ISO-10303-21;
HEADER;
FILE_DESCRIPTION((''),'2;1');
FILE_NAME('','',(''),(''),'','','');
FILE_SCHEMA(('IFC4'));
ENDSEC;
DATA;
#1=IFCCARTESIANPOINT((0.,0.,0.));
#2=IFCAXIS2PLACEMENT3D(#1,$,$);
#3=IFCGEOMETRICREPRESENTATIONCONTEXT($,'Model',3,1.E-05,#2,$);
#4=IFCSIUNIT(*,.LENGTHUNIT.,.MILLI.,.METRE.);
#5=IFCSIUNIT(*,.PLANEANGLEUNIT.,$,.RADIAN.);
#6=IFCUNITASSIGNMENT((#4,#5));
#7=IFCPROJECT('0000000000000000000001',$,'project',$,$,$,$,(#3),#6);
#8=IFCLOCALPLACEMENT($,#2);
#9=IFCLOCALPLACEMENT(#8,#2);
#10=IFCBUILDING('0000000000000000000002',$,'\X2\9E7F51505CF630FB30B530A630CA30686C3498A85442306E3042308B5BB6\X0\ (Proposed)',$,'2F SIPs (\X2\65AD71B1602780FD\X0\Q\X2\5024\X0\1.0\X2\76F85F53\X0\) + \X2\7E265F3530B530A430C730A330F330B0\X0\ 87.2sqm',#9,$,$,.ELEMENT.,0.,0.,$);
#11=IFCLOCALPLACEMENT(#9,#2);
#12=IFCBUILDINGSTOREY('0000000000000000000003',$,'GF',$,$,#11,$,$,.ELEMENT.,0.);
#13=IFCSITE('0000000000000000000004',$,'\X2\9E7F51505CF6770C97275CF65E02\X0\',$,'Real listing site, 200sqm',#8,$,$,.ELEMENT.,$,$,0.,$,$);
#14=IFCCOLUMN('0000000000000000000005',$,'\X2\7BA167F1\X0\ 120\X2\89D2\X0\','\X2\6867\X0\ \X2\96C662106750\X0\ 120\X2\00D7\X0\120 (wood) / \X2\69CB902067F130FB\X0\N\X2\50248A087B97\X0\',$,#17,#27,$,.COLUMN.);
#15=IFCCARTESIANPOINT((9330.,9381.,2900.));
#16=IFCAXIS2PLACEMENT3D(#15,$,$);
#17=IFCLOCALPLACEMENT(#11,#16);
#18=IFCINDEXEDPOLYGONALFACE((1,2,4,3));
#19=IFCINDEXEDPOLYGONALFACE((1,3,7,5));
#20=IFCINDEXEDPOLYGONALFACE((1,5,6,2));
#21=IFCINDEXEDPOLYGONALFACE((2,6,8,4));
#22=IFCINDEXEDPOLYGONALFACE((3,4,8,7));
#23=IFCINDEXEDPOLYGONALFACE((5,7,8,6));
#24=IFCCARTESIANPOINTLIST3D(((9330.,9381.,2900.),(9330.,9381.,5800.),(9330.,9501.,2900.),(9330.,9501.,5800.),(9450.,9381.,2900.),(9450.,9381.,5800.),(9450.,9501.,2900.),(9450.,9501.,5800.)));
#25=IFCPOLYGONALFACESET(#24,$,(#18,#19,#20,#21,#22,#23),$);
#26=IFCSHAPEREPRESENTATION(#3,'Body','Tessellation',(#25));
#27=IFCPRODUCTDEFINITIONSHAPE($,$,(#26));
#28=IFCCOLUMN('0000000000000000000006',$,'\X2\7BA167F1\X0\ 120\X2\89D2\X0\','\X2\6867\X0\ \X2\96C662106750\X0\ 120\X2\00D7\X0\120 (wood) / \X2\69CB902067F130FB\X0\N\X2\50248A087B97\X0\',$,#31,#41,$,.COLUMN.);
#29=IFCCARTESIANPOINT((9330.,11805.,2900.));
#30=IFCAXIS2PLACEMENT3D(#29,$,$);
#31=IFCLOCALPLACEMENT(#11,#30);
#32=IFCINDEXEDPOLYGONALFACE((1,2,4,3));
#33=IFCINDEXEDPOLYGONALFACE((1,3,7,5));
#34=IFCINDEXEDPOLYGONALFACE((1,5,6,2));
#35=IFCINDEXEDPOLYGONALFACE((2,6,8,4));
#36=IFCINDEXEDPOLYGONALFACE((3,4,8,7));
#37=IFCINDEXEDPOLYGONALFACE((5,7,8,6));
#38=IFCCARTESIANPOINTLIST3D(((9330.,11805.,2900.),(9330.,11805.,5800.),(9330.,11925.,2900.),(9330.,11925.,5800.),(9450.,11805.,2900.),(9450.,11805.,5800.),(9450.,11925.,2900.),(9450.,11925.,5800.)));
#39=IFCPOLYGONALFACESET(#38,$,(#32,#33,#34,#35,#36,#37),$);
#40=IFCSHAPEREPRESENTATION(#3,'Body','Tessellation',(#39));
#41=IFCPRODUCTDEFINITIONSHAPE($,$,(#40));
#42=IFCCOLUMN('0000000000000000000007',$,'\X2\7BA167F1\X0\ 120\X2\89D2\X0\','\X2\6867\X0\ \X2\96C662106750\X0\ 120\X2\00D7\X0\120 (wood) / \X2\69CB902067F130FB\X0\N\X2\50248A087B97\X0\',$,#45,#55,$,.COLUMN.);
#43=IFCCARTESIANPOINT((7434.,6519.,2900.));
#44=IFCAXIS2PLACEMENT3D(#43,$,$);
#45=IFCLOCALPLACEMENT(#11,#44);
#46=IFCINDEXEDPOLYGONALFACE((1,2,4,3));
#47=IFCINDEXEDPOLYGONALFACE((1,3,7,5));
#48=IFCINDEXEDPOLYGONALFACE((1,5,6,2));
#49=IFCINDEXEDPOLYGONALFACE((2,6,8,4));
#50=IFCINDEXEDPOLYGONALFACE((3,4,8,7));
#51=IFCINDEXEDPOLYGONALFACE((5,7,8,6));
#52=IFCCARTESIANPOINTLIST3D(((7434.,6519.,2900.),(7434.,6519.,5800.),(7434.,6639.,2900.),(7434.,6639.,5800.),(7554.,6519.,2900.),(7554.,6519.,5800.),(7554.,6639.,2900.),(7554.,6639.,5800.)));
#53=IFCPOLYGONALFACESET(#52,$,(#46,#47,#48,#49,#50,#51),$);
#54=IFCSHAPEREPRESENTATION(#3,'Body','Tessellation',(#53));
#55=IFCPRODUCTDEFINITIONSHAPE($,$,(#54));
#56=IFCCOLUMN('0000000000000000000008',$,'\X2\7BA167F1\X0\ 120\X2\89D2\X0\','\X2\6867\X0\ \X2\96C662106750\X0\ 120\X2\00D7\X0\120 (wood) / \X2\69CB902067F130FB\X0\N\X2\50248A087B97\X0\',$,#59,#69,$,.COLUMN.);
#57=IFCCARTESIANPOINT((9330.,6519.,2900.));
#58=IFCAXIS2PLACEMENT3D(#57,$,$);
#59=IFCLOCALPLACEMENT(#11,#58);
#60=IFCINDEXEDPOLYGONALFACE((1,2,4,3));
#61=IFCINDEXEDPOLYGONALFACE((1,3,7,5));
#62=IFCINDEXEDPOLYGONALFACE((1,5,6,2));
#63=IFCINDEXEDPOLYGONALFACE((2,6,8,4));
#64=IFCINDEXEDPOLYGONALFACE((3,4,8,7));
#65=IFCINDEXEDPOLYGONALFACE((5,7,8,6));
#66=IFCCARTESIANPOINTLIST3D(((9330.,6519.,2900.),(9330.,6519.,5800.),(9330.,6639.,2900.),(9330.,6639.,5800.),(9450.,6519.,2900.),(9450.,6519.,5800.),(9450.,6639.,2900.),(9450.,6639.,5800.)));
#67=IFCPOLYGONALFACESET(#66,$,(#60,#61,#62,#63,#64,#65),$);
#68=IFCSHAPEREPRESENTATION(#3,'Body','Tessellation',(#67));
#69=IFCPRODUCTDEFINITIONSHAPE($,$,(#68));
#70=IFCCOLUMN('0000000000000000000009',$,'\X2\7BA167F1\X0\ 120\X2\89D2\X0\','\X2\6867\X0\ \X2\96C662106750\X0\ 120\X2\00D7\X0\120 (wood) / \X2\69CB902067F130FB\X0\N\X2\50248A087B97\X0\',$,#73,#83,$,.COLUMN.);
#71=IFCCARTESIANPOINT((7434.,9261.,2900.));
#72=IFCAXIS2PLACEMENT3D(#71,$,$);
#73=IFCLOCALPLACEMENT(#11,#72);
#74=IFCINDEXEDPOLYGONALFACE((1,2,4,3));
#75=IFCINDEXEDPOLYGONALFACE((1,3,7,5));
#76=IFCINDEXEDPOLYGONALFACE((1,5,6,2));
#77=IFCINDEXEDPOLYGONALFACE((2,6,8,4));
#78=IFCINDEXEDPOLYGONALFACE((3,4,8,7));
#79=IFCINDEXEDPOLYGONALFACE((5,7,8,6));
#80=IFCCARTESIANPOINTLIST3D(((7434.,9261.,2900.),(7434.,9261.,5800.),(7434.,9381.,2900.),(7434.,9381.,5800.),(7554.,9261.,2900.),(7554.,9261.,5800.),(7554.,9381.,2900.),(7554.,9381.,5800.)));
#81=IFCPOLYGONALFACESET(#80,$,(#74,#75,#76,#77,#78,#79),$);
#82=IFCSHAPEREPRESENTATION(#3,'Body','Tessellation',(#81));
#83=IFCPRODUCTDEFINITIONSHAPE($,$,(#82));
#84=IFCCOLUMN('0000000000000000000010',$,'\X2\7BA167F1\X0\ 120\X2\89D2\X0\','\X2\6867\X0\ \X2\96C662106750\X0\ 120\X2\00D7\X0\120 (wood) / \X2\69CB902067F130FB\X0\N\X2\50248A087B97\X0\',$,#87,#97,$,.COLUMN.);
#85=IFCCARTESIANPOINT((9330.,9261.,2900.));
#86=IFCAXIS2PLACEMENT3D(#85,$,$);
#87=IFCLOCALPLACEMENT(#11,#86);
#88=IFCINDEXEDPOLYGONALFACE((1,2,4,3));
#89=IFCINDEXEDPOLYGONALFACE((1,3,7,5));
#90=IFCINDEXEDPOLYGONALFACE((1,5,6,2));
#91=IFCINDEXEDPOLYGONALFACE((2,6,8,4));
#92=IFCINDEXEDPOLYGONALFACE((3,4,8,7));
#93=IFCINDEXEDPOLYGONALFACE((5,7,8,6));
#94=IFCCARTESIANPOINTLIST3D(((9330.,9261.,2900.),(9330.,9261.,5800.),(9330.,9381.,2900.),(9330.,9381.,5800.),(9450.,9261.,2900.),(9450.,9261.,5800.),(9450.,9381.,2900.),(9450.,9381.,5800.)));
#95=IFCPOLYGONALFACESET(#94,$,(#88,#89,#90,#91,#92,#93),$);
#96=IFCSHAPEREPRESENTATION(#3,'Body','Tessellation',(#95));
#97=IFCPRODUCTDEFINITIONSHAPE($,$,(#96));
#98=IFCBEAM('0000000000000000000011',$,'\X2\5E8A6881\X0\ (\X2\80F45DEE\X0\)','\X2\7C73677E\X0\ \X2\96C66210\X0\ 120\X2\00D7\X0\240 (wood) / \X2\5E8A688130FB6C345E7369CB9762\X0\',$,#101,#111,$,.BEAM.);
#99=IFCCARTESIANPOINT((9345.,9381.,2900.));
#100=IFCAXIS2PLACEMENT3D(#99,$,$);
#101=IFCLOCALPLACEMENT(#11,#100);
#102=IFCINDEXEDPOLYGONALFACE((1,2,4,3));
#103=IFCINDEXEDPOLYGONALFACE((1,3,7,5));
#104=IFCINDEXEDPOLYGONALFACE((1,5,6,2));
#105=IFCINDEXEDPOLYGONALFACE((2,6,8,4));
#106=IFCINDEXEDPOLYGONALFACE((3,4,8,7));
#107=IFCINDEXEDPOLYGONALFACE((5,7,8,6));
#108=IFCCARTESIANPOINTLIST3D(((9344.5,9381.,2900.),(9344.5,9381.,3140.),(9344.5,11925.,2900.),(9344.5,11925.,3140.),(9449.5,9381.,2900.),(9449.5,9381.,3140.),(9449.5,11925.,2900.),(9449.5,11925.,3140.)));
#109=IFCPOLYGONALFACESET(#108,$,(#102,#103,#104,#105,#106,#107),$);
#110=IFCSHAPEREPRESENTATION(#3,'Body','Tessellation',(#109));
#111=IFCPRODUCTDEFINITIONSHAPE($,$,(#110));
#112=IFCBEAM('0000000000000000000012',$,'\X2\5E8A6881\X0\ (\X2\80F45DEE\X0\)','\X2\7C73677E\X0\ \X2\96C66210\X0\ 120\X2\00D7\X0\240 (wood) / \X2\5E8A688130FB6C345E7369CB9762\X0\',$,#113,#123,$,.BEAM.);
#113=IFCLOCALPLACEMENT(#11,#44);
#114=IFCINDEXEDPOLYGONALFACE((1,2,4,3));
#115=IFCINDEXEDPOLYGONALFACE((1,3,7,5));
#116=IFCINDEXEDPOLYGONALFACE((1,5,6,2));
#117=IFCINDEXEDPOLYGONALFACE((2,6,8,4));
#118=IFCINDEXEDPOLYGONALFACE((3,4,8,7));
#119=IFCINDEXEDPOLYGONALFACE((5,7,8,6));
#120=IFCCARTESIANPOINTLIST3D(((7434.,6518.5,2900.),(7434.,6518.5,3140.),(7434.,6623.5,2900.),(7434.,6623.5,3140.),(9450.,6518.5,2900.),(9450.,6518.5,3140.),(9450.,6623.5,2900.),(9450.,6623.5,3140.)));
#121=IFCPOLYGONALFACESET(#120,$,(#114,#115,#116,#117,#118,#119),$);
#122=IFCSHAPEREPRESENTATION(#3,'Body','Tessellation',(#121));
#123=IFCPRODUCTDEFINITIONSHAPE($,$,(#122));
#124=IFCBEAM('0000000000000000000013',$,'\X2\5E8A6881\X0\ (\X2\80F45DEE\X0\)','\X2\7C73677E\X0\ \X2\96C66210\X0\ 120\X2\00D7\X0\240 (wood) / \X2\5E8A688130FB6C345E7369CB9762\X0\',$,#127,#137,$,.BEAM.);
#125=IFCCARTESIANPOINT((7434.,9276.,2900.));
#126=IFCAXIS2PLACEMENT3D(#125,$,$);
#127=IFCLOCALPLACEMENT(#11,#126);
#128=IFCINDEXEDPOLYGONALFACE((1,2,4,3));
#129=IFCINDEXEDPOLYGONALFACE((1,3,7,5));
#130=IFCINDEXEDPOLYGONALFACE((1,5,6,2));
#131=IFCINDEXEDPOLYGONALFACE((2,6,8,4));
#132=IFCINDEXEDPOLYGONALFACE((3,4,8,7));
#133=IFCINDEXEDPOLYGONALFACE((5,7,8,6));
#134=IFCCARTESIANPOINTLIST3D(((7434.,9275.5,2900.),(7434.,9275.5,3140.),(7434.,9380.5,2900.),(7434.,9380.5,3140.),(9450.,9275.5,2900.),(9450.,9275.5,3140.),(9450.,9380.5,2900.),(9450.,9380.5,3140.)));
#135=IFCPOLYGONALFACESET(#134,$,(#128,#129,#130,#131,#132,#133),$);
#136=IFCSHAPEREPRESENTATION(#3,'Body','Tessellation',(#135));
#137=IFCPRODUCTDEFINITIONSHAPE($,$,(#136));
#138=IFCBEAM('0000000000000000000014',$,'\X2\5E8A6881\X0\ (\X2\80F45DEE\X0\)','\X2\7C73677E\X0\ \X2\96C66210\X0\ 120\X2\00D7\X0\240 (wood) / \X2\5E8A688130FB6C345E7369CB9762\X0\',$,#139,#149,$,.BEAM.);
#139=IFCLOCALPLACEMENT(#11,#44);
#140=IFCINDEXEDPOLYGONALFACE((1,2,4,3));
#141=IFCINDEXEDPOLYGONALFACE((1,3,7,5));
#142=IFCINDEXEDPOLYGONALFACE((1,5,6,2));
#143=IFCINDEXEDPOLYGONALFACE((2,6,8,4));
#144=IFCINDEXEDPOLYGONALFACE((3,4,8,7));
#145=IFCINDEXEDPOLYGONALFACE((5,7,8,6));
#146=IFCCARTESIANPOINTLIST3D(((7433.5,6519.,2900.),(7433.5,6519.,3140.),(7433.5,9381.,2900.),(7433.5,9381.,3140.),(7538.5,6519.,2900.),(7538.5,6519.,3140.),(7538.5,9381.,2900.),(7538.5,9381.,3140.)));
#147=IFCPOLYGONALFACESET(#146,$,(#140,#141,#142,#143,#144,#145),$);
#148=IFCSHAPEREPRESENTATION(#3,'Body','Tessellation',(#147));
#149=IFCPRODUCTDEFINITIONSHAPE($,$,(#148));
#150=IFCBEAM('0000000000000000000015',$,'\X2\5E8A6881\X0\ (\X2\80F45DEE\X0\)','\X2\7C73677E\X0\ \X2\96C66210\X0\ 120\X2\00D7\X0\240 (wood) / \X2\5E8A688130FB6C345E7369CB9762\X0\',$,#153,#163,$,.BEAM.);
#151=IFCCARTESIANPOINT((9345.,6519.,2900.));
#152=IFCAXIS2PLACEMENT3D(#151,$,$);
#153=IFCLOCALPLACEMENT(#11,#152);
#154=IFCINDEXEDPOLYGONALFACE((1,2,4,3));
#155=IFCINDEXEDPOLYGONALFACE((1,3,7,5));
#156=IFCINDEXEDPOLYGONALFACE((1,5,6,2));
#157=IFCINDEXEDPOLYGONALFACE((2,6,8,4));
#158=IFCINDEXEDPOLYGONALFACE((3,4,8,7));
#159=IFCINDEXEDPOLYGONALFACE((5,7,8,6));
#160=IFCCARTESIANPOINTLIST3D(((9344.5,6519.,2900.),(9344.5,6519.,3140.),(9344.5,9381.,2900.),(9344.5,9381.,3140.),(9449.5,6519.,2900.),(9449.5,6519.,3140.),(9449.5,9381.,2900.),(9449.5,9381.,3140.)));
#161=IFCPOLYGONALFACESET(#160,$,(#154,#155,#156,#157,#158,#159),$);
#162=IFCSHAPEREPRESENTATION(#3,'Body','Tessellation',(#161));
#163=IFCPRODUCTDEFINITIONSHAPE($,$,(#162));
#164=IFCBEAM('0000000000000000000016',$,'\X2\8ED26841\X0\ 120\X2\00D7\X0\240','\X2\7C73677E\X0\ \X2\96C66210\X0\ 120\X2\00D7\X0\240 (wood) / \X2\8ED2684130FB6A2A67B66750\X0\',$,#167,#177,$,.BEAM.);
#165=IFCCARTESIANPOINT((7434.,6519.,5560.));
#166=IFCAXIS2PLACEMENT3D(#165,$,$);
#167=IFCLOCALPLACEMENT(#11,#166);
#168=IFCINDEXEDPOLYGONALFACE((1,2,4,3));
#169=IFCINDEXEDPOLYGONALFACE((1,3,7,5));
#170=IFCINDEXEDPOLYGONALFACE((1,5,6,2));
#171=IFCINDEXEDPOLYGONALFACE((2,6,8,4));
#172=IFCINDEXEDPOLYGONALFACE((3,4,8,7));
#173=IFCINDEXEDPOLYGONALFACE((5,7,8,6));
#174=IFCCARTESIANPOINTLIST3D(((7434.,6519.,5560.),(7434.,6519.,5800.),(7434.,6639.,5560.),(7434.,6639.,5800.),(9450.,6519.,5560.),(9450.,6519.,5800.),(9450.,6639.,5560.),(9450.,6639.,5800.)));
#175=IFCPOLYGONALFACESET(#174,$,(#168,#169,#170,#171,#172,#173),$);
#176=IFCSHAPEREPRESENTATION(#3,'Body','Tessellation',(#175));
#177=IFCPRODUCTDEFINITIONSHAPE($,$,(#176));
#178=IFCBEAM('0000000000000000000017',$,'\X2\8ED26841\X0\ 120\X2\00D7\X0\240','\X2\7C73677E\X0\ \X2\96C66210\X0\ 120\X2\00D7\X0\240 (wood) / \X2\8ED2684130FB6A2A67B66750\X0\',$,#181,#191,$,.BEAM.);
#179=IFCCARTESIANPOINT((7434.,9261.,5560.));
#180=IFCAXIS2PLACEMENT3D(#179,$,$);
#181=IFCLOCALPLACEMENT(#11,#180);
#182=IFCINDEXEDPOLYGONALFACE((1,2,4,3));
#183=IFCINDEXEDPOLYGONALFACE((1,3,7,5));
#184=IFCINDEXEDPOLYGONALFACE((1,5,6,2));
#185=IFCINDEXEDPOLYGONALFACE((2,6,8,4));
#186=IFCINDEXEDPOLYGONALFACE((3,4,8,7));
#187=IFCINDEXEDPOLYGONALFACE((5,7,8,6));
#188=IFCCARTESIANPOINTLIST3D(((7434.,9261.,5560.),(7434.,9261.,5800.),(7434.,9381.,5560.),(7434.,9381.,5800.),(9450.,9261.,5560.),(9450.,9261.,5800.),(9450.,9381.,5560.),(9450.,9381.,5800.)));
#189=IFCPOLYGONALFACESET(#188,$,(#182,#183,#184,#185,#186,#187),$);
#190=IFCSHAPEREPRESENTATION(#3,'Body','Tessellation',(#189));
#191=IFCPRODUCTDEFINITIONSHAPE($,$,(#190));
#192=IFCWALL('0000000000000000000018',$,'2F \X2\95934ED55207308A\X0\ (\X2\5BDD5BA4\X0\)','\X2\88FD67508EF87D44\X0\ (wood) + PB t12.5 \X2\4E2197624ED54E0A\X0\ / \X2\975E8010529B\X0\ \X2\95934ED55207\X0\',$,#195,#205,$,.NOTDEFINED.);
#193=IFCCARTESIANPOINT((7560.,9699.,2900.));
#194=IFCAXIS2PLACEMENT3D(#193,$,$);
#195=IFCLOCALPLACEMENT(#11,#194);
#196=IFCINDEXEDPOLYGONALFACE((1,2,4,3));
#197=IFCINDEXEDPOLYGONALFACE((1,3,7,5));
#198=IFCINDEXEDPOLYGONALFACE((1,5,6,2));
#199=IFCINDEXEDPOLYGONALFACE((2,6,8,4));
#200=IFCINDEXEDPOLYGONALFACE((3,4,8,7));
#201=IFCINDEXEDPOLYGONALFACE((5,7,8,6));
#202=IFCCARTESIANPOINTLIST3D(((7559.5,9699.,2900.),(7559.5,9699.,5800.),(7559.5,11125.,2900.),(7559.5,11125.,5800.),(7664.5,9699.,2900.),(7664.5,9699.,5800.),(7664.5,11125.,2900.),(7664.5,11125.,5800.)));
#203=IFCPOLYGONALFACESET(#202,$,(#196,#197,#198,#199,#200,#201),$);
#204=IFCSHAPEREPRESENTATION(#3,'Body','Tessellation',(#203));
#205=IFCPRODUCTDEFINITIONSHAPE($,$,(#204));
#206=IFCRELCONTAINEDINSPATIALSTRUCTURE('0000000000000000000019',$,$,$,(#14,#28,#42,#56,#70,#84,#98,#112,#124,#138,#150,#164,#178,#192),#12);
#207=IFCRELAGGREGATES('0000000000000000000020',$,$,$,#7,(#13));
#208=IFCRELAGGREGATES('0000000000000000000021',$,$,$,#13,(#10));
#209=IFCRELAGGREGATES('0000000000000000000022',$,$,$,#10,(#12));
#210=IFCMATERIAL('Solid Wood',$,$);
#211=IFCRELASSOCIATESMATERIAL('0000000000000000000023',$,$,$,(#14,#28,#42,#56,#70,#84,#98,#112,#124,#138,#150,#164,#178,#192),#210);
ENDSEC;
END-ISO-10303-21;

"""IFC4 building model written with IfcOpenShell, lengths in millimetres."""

from ifc_helpers import new_model, si_unit, frame, frame_2d, origin, place, context, project, spatial, rectangle, extrude, material, element, save


model = new_model("IFC4")

# Units and contexts
model_context = context("Model", 3, precision=1e-05, world=origin())
ifc_project = project(units=[si_unit("LENGTHUNIT", "METRE", prefix="MILLI"), si_unit("PLANEANGLEUNIT", "RADIAN")], contexts=[model_context])

# Site, building, storey
site_placement = place(None, origin())
site = spatial("IfcSite", under=ifc_project, at=site_placement, Name="鹿児島県霧島市", ObjectType="Real listing site, 200sqm", CompositionType="ELEMENT", RefElevation=0.0)
building_placement = place(site_placement, origin())
building = spatial("IfcBuilding", under=site, at=building_placement, Name="鹿児島・サウナと水風呂のある家 (Proposed)", ObjectType="2F SIPs (断熱性能Q値1.0相当) + 縦張サイディング 87.2sqm", CompositionType="ELEMENT", ElevationOfRefHeight=0.0, ElevationOfTerrain=0.0)
storey_placement = place(building_placement, origin())
storey = spatial("IfcBuildingStorey", under=building, at=storey_placement, Name="GF", CompositionType="ELEMENT", Elevation=0.0)

# Columns
ifc_material_1 = material(Name="Solid Wood")
column_1_placement = place(storey_placement, frame((9330.0, 9381.0, 2900.0)))
element("IfcColumn", 1, at=column_1_placement, inside=storey, material=ifc_material_1, Name="管柱 120角", Description="桧 集成材 120×120 (wood) / 構造柱・N値計算", PredefinedType="COLUMN", context=model_context, shape_type="SweptSolid", body=[
    extrude(rectangle(XDim=120.0, YDim=120.0, at=frame_2d((60.0, 60.0))), frame((9330.0, 9381.0, 2900.0)), (0.0, 0.0, 1.0), 2900.0),
])
column_2_placement = place(storey_placement, frame((9330.0, 11805.0, 2900.0)))
element("IfcColumn", 2, at=column_2_placement, inside=storey, material=ifc_material_1, Name="管柱 120角", Description="桧 集成材 120×120 (wood) / 構造柱・N値計算", PredefinedType="COLUMN", context=model_context, shape_type="SweptSolid", body=[
    extrude(rectangle(XDim=120.0, YDim=120.0, at=frame_2d((60.0, 60.0))), frame((9330.0, 11805.0, 2900.0)), (0.0, 0.0, 1.0), 2900.0),
])
column_3_placement = place(storey_placement, frame((7434.0, 6519.0, 2900.0)))
element("IfcColumn", 3, at=column_3_placement, inside=storey, material=ifc_material_1, Name="管柱 120角", Description="桧 集成材 120×120 (wood) / 構造柱・N値計算", PredefinedType="COLUMN", context=model_context, shape_type="SweptSolid", body=[
    extrude(rectangle(XDim=120.0, YDim=120.0, at=frame_2d((60.0, 60.0))), frame((7434.0, 6519.0, 2900.0)), (0.0, 0.0, 1.0), 2900.0),
])
column_4_placement = place(storey_placement, frame((9330.0, 6519.0, 2900.0)))
element("IfcColumn", 4, at=column_4_placement, inside=storey, material=ifc_material_1, Name="管柱 120角", Description="桧 集成材 120×120 (wood) / 構造柱・N値計算", PredefinedType="COLUMN", context=model_context, shape_type="SweptSolid", body=[
    extrude(rectangle(XDim=120.0, YDim=120.0, at=frame_2d((60.0, 60.0))), frame((9330.0, 6519.0, 2900.0)), (0.0, 0.0, 1.0), 2900.0),
])
column_5_placement = place(storey_placement, frame((7434.0, 9261.0, 2900.0)))
element("IfcColumn", 5, at=column_5_placement, inside=storey, material=ifc_material_1, Name="管柱 120角", Description="桧 集成材 120×120 (wood) / 構造柱・N値計算", PredefinedType="COLUMN", context=model_context, shape_type="SweptSolid", body=[
    extrude(rectangle(XDim=120.0, YDim=120.0, at=frame_2d((60.0, 60.0))), frame((7434.0, 9261.0, 2900.0)), (0.0, 0.0, 1.0), 2900.0),
])
column_6_placement = place(storey_placement, frame((9330.0, 9261.0, 2900.0)))
element("IfcColumn", 6, at=column_6_placement, inside=storey, material=ifc_material_1, Name="管柱 120角", Description="桧 集成材 120×120 (wood) / 構造柱・N値計算", PredefinedType="COLUMN", context=model_context, shape_type="SweptSolid", body=[
    extrude(rectangle(XDim=120.0, YDim=120.0, at=frame_2d((60.0, 60.0))), frame((9330.0, 9261.0, 2900.0)), (0.0, 0.0, 1.0), 2900.0),
])

# Beams
beam_1_placement = place(storey_placement, frame((9345.0, 9381.0, 2900.0)))
element("IfcBeam", 7, at=beam_1_placement, inside=storey, material=ifc_material_1, Name="床梁 (胴差)", Description="米松 集成 120×240 (wood) / 床梁・水平構面", PredefinedType="BEAM", context=model_context, shape_type="SweptSolid", body=[
    extrude(rectangle(XDim=105.0, YDim=2544.0, at=frame_2d((52.0, 1272.0))), frame((9345.0, 9381.0, 2900.0)), (0.0, 0.0, 1.0), 240.0),
])
beam_2_placement = place(storey_placement, frame((7434.0, 6519.0, 2900.0)))
element("IfcBeam", 8, at=beam_2_placement, inside=storey, material=ifc_material_1, Name="床梁 (胴差)", Description="米松 集成 120×240 (wood) / 床梁・水平構面", PredefinedType="BEAM", context=model_context, shape_type="SweptSolid", body=[
    extrude(rectangle(XDim=2016.0, YDim=105.0, at=frame_2d((1008.0, 52.0))), frame((7434.0, 6519.0, 2900.0)), (0.0, 0.0, 1.0), 240.0),
])
beam_3_placement = place(storey_placement, frame((7434.0, 9276.0, 2900.0)))
element("IfcBeam", 9, at=beam_3_placement, inside=storey, material=ifc_material_1, Name="床梁 (胴差)", Description="米松 集成 120×240 (wood) / 床梁・水平構面", PredefinedType="BEAM", context=model_context, shape_type="SweptSolid", body=[
    extrude(rectangle(XDim=2016.0, YDim=105.0, at=frame_2d((1008.0, 52.0))), frame((7434.0, 9276.0, 2900.0)), (0.0, 0.0, 1.0), 240.0),
])
beam_4_placement = place(storey_placement, frame((7434.0, 6519.0, 2900.0)))
element("IfcBeam", 10, at=beam_4_placement, inside=storey, material=ifc_material_1, Name="床梁 (胴差)", Description="米松 集成 120×240 (wood) / 床梁・水平構面", PredefinedType="BEAM", context=model_context, shape_type="SweptSolid", body=[
    extrude(rectangle(XDim=105.0, YDim=2862.0, at=frame_2d((52.0, 1431.0))), frame((7434.0, 6519.0, 2900.0)), (0.0, 0.0, 1.0), 240.0),
])
beam_5_placement = place(storey_placement, frame((9345.0, 6519.0, 2900.0)))
element("IfcBeam", 11, at=beam_5_placement, inside=storey, material=ifc_material_1, Name="床梁 (胴差)", Description="米松 集成 120×240 (wood) / 床梁・水平構面", PredefinedType="BEAM", context=model_context, shape_type="SweptSolid", body=[
    extrude(rectangle(XDim=105.0, YDim=2862.0, at=frame_2d((52.0, 1431.0))), frame((9345.0, 6519.0, 2900.0)), (0.0, 0.0, 1.0), 240.0),
])
beam_6_placement = place(storey_placement, frame((7434.0, 6519.0, 5560.0)))
element("IfcBeam", 12, at=beam_6_placement, inside=storey, material=ifc_material_1, Name="軒桁 120×240", Description="米松 集成 120×240 (wood) / 軒桁・横架材", PredefinedType="BEAM", context=model_context, shape_type="SweptSolid", body=[
    extrude(rectangle(XDim=2016.0, YDim=120.0, at=frame_2d((1008.0, 60.0))), frame((7434.0, 6519.0, 5560.0)), (0.0, 0.0, 1.0), 240.0),
])
beam_7_placement = place(storey_placement, frame((7434.0, 9261.0, 5560.0)))
element("IfcBeam", 13, at=beam_7_placement, inside=storey, material=ifc_material_1, Name="軒桁 120×240", Description="米松 集成 120×240 (wood) / 軒桁・横架材", PredefinedType="BEAM", context=model_context, shape_type="SweptSolid", body=[
    extrude(rectangle(XDim=2016.0, YDim=120.0, at=frame_2d((1008.0, 60.0))), frame((7434.0, 9261.0, 5560.0)), (0.0, 0.0, 1.0), 240.0),
])

# Wall
wall_placement = place(storey_placement, frame((7560.0, 9699.0, 2900.0)))
element("IfcWall", 14, at=wall_placement, inside=storey, material=ifc_material_1, Name="2F 間仕切り (寝室)", Description="製材軸組 (wood) + PB t12.5 両面仕上 / 非耐力 間仕切", PredefinedType="NOTDEFINED", context=model_context, shape_type="SweptSolid", body=[
    extrude(rectangle(XDim=105.0, YDim=1426.0, at=frame_2d((52.0, 713.0))), frame((7560.0, 9699.0, 2900.0)), (0.0, 0.0, 1.0), 2900.0),
])

save(model, "model.ifc")
